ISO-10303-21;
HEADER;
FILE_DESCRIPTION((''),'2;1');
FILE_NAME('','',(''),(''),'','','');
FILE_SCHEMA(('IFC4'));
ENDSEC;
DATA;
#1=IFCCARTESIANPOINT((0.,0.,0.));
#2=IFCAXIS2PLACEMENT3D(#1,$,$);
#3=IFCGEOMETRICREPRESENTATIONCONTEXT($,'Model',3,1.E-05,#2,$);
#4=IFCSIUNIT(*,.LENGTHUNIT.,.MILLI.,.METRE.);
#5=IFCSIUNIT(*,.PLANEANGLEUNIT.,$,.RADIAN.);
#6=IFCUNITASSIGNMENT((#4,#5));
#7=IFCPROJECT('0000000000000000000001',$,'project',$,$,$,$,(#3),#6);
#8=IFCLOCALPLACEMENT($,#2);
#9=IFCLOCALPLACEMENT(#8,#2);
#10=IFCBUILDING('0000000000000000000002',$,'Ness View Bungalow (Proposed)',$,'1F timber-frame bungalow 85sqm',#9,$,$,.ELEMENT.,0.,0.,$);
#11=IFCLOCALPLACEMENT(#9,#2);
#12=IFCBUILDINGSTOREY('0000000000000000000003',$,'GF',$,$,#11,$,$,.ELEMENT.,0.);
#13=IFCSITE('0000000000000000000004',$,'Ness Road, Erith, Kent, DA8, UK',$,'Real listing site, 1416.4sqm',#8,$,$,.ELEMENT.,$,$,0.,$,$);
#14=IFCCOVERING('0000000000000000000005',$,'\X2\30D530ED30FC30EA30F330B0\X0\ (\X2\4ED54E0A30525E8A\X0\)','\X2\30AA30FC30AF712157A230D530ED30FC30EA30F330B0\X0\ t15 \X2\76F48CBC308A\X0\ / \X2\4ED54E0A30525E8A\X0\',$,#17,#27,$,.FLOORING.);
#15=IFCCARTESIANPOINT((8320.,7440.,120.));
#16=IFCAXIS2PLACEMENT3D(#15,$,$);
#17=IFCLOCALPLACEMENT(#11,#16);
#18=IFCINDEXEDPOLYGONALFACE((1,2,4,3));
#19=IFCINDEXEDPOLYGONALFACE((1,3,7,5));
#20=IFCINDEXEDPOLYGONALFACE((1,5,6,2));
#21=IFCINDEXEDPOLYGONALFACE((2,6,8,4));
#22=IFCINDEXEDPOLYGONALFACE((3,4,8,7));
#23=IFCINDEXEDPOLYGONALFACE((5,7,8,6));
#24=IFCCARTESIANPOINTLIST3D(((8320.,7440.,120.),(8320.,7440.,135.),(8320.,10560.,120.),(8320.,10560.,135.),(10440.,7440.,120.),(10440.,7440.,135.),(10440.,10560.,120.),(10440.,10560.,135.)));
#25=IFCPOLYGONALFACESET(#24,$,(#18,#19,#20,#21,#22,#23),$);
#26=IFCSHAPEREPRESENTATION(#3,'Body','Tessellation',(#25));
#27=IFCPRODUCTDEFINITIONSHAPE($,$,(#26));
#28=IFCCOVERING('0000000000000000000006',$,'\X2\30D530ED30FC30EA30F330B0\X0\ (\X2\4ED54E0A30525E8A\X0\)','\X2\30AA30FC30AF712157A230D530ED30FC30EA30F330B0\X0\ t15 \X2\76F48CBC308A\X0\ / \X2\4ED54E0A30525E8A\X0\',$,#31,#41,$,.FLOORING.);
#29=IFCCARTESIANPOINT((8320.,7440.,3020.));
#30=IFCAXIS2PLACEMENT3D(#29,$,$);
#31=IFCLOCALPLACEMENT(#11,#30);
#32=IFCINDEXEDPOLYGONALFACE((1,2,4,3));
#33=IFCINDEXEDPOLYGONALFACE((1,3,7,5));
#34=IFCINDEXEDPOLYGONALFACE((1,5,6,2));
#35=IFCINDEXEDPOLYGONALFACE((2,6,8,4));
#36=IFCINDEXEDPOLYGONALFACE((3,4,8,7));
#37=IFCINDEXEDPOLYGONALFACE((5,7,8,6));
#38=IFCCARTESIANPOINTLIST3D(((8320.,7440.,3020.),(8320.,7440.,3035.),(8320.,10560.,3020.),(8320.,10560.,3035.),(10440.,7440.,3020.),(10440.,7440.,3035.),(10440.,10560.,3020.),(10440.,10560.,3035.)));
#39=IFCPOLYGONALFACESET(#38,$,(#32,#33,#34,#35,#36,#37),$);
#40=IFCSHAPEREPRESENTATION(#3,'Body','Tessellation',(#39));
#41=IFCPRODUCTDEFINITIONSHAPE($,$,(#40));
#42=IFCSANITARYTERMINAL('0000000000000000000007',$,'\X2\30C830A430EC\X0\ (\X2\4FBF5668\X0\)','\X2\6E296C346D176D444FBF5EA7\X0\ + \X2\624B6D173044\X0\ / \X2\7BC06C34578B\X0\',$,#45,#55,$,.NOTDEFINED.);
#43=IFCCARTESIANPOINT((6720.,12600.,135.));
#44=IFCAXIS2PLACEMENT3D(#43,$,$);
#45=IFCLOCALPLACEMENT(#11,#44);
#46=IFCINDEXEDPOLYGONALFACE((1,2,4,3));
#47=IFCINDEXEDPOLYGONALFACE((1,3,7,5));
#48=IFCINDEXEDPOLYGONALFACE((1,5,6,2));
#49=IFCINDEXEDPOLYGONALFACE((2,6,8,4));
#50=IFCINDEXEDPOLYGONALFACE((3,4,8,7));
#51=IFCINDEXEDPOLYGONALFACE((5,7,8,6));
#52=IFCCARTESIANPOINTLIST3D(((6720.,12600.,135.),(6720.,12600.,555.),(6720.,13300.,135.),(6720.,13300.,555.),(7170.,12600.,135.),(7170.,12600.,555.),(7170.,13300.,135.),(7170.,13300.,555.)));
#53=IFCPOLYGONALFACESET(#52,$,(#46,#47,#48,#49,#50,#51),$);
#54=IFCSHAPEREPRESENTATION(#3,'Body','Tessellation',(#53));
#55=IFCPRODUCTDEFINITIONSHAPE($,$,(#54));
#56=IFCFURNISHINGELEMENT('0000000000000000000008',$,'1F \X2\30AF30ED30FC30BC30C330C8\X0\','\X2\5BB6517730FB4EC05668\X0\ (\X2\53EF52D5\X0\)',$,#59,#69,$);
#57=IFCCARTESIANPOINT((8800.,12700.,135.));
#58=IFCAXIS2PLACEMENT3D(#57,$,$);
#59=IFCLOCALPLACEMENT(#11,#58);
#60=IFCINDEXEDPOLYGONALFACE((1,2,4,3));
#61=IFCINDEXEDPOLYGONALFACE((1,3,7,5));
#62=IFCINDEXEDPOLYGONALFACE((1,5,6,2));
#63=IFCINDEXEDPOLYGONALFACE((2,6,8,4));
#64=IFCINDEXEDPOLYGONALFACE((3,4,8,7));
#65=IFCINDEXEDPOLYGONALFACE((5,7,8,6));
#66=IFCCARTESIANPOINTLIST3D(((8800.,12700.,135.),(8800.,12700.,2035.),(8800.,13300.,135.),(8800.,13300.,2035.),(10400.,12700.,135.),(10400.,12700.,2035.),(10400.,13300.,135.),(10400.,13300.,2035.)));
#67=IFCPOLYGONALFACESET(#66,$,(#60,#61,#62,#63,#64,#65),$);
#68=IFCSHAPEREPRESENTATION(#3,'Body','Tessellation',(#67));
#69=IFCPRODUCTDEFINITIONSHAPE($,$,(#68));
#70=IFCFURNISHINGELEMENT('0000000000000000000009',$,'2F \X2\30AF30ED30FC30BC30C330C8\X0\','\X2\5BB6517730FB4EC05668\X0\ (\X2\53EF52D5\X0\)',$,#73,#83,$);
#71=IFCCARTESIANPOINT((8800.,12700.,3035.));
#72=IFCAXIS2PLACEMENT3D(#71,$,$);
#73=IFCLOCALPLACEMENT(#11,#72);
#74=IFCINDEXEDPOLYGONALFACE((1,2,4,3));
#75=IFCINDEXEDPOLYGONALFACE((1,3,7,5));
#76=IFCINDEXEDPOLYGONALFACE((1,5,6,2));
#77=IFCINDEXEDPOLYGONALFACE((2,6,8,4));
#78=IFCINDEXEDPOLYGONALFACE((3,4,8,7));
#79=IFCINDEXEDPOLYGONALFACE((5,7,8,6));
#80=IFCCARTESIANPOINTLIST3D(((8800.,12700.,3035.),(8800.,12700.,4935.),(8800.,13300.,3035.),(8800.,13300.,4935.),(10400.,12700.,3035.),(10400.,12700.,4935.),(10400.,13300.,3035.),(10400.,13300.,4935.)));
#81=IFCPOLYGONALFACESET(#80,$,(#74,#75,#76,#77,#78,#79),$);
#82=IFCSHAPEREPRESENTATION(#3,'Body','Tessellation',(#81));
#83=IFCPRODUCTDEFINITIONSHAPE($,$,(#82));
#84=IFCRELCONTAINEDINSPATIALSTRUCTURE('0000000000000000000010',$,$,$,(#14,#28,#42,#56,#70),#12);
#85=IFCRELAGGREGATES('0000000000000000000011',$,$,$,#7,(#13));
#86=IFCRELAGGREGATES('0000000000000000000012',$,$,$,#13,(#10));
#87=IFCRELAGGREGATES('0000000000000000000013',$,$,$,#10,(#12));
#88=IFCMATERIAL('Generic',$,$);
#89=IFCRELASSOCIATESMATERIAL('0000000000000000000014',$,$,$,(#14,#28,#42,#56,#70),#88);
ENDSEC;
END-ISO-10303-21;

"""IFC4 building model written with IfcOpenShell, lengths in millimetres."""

from ifc_helpers import new_model, si_unit, frame, frame_2d, origin, place, context, project, spatial, rectangle, extrude, material, element, save


model = new_model("IFC4")

# Units and contexts
model_context = context("Model", 3, precision=1e-05, world=origin())
ifc_project = project(units=[si_unit("LENGTHUNIT", "METRE", prefix="MILLI"), si_unit("PLANEANGLEUNIT", "RADIAN")], contexts=[model_context])

# Site, building, storey
site_placement = place(None, origin())
site = spatial("IfcSite", under=ifc_project, at=site_placement, Name="Ness Road, Erith, Kent, DA8, UK", ObjectType="Real listing site, 1416.4sqm", CompositionType="ELEMENT", RefElevation=0.0)
building_placement = place(site_placement, origin())
building = spatial("IfcBuilding", under=site, at=building_placement, Name="Ness View Bungalow (Proposed)", ObjectType="1F timber-frame bungalow 85sqm", CompositionType="ELEMENT", ElevationOfRefHeight=0.0, ElevationOfTerrain=0.0)
storey_placement = place(building_placement, origin())
storey = spatial("IfcBuildingStorey", under=building, at=storey_placement, Name="GF", CompositionType="ELEMENT", Elevation=0.0)

# Shared definitions
ifc_material_1 = material(Name="Generic")

# Coverings
covering_1_placement = place(storey_placement, frame((8320.0, 7440.0, 120.0)))
element("IfcCovering", 1, at=covering_1_placement, inside=storey, material=ifc_material_1, Name="フローリング (仕上げ床)", Description="オーク無垢フローリング t15 直貼り / 仕上げ床", PredefinedType="FLOORING", context=model_context, shape_type="SweptSolid", body=[
    extrude(rectangle(XDim=2120.0, YDim=3120.0, at=frame_2d((1060.0, 1560.0))), frame((8320.0, 7440.0, 120.0)), (0.0, 0.0, 1.0), 15.0),
])
covering_2_placement = place(storey_placement, frame((8320.0, 7440.0, 3020.0)))
element("IfcCovering", 2, at=covering_2_placement, inside=storey, material=ifc_material_1, Name="フローリング (仕上げ床)", Description="オーク無垢フローリング t15 直貼り / 仕上げ床", PredefinedType="FLOORING", context=model_context, shape_type="SweptSolid", body=[
    extrude(rectangle(XDim=2120.0, YDim=3120.0, at=frame_2d((1060.0, 1560.0))), frame((8320.0, 7440.0, 3020.0)), (0.0, 0.0, 1.0), 15.0),
])

# Sanitary terminal
sanitary_terminal_placement = place(storey_placement, frame((6720.0, 12600.0, 135.0)))
element("IfcSanitaryTerminal", 3, at=sanitary_terminal_placement, inside=storey, material=ifc_material_1, Name="トイレ (便器)", Description="温水洗浄便座 + 手洗い / 節水型", PredefinedType="NOTDEFINED", context=model_context, shape_type="SweptSolid", body=[
    extrude(rectangle(XDim=450.0, YDim=700.0, at=frame_2d((225.0, 350.0))), frame((6720.0, 12600.0, 135.0)), (0.0, 0.0, 1.0), 420.0),
])

# Furnishing elements
furnishing_1_placement = place(storey_placement, frame((8800.0, 12700.0, 135.0)))
element("IfcFurnishingElement", 4, at=furnishing_1_placement, inside=storey, material=ifc_material_1, Name="1F クローゼット", Description="家具・什器 (可動)", context=model_context, shape_type="SweptSolid", body=[
    extrude(rectangle(XDim=1600.0, YDim=600.0, at=frame_2d((800.0, 300.0))), frame((8800.0, 12700.0, 135.0)), (0.0, 0.0, 1.0), 1900.0),
])
furnishing_2_placement = place(storey_placement, frame((8800.0, 12700.0, 3035.0)))
element("IfcFurnishingElement", 5, at=furnishing_2_placement, inside=storey, material=ifc_material_1, Name="2F クローゼット", Description="家具・什器 (可動)", context=model_context, shape_type="SweptSolid", body=[
    extrude(rectangle(XDim=1600.0, YDim=600.0, at=frame_2d((800.0, 300.0))), frame((8800.0, 12700.0, 3035.0)), (0.0, 0.0, 1.0), 1900.0),
])

save(model, "model.ifc")
